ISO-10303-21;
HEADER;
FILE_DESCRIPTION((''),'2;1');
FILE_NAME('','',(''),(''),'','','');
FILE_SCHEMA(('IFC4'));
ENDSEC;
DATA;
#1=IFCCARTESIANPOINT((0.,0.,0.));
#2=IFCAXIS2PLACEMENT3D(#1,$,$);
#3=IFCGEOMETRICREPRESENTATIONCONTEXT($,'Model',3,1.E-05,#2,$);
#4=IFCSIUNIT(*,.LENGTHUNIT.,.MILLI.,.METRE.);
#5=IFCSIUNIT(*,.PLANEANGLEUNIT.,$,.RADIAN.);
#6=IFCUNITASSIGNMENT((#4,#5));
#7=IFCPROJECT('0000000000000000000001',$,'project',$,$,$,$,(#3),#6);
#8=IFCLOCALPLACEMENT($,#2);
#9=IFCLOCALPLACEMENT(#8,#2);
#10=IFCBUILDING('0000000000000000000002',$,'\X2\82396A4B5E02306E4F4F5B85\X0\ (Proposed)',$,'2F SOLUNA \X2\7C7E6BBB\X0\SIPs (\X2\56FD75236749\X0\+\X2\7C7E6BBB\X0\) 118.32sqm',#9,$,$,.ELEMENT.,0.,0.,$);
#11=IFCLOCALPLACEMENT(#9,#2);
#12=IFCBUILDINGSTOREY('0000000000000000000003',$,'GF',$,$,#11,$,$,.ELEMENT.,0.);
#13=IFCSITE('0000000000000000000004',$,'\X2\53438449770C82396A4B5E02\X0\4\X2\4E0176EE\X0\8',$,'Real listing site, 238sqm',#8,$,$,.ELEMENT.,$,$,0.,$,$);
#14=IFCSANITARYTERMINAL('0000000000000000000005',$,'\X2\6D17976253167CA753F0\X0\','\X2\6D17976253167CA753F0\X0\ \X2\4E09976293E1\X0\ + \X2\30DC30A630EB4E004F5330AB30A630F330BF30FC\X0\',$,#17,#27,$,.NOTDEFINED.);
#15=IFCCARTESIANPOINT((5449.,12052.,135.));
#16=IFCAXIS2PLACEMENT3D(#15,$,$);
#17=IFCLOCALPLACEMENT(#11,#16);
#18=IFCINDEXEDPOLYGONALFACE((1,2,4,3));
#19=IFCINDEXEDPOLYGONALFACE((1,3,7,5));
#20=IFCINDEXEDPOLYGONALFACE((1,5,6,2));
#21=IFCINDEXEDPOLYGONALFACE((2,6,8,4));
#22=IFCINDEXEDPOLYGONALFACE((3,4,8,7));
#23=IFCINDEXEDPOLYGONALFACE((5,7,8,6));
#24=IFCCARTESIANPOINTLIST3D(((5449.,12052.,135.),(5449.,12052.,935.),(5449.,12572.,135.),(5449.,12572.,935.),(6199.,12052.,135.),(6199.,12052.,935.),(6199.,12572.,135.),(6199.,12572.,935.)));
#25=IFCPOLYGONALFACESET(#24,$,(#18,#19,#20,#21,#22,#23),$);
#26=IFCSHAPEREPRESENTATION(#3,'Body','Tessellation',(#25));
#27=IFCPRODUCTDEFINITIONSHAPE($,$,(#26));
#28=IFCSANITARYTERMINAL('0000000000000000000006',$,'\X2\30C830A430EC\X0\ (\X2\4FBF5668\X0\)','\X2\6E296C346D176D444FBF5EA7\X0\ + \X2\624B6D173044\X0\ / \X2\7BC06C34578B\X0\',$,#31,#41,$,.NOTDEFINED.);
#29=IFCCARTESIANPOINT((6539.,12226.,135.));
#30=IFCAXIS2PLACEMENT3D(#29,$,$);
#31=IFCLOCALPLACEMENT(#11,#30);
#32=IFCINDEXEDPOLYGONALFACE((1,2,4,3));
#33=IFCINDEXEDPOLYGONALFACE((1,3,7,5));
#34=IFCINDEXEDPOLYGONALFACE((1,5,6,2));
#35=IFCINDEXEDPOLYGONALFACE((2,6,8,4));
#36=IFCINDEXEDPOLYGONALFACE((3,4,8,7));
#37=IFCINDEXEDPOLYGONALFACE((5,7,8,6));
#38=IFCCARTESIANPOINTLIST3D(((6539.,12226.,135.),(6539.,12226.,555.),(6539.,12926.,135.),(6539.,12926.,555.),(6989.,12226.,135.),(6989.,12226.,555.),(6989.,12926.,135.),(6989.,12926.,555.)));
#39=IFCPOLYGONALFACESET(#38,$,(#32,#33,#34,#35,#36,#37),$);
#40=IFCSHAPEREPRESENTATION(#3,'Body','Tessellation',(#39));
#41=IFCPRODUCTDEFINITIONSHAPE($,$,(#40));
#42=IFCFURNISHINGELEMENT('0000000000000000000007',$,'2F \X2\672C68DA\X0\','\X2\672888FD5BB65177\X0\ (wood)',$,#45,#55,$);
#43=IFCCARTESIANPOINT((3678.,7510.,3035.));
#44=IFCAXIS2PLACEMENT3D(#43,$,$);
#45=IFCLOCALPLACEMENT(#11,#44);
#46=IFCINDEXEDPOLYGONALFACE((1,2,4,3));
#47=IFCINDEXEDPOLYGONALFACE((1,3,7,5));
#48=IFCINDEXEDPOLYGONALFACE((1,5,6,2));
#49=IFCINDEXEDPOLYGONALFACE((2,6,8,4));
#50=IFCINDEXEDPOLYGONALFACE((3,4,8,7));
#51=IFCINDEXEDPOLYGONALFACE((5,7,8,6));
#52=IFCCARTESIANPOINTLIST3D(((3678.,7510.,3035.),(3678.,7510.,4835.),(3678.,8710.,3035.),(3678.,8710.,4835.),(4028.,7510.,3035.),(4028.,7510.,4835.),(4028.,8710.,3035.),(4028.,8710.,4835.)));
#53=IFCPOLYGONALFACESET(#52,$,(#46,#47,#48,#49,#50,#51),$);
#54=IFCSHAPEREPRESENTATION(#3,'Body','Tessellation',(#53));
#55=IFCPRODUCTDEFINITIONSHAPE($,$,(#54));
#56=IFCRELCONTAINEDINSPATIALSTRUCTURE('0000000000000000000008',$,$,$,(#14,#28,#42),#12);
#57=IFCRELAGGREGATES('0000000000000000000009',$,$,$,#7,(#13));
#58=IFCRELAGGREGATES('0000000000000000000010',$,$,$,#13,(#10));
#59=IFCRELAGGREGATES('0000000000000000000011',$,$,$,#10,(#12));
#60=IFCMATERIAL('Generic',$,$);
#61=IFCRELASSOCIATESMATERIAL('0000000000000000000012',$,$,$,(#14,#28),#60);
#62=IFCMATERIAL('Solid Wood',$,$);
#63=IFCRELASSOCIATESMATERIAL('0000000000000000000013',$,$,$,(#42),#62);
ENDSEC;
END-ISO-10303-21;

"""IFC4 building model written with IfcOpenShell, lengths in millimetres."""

from ifc_helpers import new_model, si_unit, frame, frame_2d, origin, place, context, project, spatial, rectangle, extrude, material, element, save


model = new_model("IFC4")

# Units and contexts
model_context = context("Model", 3, precision=1e-05, world=origin())
ifc_project = project(units=[si_unit("LENGTHUNIT", "METRE", prefix="MILLI"), si_unit("PLANEANGLEUNIT", "RADIAN")], contexts=[model_context])

# Site, building, storey
site_placement = place(None, origin())
site = spatial("IfcSite", under=ifc_project, at=site_placement, Name="千葉県船橋市4丁目8", ObjectType="Real listing site, 238sqm", CompositionType="ELEMENT", RefElevation=0.0)
building_placement = place(site_placement, origin())
building = spatial("IfcBuilding", under=site, at=building_placement, Name="船橋市の住宅 (Proposed)", ObjectType="2F SOLUNA 籾殻SIPs (国産杉+籾殻) 118.32sqm", CompositionType="ELEMENT", ElevationOfRefHeight=0.0, ElevationOfTerrain=0.0)
storey_placement = place(building_placement, origin())
storey = spatial("IfcBuildingStorey", under=building, at=storey_placement, Name="GF", CompositionType="ELEMENT", Elevation=0.0)

# Shared definitions
ifc_material_1 = material(Name="Solid Wood")

# Shared definitions
ifc_material_2 = material(Name="Generic")

# Sanitary terminals
sanitary_terminal_1_placement = place(storey_placement, frame((5449.0, 12052.0, 135.0)))
element("IfcSanitaryTerminal", 1, at=sanitary_terminal_1_placement, inside=storey, material=ifc_material_2, Name="洗面化粧台", Description="洗面化粧台 三面鏡 + ボウル一体カウンター", PredefinedType="NOTDEFINED", context=model_context, shape_type="SweptSolid", body=[
    extrude(rectangle(XDim=750.0, YDim=520.0, at=frame_2d((375.0, 260.0))), frame((5449.0, 12052.0, 135.0)), (0.0, 0.0, 1.0), 800.0),
])
sanitary_terminal_2_placement = place(storey_placement, frame((6539.0, 12226.0, 135.0)))
element("IfcSanitaryTerminal", 2, at=sanitary_terminal_2_placement, inside=storey, material=ifc_material_2, Name="トイレ (便器)", Description="温水洗浄便座 + 手洗い / 節水型", PredefinedType="NOTDEFINED", context=model_context, shape_type="SweptSolid", body=[
    extrude(rectangle(XDim=450.0, YDim=700.0, at=frame_2d((225.0, 350.0))), frame((6539.0, 12226.0, 135.0)), (0.0, 0.0, 1.0), 420.0),
])

# Furnishing element
furnishing_placement = place(storey_placement, frame((3678.0, 7510.0, 3035.0)))
element("IfcFurnishingElement", 3, at=furnishing_placement, inside=storey, material=ifc_material_1, Name="2F 本棚", Description="木製家具 (wood)", context=model_context, shape_type="SweptSolid", body=[
    extrude(rectangle(XDim=350.0, YDim=1200.0, at=frame_2d((175.0, 600.0))), frame((3678.0, 7510.0, 3035.0)), (0.0, 0.0, 1.0), 1800.0),
])

save(model, "model.ifc")
